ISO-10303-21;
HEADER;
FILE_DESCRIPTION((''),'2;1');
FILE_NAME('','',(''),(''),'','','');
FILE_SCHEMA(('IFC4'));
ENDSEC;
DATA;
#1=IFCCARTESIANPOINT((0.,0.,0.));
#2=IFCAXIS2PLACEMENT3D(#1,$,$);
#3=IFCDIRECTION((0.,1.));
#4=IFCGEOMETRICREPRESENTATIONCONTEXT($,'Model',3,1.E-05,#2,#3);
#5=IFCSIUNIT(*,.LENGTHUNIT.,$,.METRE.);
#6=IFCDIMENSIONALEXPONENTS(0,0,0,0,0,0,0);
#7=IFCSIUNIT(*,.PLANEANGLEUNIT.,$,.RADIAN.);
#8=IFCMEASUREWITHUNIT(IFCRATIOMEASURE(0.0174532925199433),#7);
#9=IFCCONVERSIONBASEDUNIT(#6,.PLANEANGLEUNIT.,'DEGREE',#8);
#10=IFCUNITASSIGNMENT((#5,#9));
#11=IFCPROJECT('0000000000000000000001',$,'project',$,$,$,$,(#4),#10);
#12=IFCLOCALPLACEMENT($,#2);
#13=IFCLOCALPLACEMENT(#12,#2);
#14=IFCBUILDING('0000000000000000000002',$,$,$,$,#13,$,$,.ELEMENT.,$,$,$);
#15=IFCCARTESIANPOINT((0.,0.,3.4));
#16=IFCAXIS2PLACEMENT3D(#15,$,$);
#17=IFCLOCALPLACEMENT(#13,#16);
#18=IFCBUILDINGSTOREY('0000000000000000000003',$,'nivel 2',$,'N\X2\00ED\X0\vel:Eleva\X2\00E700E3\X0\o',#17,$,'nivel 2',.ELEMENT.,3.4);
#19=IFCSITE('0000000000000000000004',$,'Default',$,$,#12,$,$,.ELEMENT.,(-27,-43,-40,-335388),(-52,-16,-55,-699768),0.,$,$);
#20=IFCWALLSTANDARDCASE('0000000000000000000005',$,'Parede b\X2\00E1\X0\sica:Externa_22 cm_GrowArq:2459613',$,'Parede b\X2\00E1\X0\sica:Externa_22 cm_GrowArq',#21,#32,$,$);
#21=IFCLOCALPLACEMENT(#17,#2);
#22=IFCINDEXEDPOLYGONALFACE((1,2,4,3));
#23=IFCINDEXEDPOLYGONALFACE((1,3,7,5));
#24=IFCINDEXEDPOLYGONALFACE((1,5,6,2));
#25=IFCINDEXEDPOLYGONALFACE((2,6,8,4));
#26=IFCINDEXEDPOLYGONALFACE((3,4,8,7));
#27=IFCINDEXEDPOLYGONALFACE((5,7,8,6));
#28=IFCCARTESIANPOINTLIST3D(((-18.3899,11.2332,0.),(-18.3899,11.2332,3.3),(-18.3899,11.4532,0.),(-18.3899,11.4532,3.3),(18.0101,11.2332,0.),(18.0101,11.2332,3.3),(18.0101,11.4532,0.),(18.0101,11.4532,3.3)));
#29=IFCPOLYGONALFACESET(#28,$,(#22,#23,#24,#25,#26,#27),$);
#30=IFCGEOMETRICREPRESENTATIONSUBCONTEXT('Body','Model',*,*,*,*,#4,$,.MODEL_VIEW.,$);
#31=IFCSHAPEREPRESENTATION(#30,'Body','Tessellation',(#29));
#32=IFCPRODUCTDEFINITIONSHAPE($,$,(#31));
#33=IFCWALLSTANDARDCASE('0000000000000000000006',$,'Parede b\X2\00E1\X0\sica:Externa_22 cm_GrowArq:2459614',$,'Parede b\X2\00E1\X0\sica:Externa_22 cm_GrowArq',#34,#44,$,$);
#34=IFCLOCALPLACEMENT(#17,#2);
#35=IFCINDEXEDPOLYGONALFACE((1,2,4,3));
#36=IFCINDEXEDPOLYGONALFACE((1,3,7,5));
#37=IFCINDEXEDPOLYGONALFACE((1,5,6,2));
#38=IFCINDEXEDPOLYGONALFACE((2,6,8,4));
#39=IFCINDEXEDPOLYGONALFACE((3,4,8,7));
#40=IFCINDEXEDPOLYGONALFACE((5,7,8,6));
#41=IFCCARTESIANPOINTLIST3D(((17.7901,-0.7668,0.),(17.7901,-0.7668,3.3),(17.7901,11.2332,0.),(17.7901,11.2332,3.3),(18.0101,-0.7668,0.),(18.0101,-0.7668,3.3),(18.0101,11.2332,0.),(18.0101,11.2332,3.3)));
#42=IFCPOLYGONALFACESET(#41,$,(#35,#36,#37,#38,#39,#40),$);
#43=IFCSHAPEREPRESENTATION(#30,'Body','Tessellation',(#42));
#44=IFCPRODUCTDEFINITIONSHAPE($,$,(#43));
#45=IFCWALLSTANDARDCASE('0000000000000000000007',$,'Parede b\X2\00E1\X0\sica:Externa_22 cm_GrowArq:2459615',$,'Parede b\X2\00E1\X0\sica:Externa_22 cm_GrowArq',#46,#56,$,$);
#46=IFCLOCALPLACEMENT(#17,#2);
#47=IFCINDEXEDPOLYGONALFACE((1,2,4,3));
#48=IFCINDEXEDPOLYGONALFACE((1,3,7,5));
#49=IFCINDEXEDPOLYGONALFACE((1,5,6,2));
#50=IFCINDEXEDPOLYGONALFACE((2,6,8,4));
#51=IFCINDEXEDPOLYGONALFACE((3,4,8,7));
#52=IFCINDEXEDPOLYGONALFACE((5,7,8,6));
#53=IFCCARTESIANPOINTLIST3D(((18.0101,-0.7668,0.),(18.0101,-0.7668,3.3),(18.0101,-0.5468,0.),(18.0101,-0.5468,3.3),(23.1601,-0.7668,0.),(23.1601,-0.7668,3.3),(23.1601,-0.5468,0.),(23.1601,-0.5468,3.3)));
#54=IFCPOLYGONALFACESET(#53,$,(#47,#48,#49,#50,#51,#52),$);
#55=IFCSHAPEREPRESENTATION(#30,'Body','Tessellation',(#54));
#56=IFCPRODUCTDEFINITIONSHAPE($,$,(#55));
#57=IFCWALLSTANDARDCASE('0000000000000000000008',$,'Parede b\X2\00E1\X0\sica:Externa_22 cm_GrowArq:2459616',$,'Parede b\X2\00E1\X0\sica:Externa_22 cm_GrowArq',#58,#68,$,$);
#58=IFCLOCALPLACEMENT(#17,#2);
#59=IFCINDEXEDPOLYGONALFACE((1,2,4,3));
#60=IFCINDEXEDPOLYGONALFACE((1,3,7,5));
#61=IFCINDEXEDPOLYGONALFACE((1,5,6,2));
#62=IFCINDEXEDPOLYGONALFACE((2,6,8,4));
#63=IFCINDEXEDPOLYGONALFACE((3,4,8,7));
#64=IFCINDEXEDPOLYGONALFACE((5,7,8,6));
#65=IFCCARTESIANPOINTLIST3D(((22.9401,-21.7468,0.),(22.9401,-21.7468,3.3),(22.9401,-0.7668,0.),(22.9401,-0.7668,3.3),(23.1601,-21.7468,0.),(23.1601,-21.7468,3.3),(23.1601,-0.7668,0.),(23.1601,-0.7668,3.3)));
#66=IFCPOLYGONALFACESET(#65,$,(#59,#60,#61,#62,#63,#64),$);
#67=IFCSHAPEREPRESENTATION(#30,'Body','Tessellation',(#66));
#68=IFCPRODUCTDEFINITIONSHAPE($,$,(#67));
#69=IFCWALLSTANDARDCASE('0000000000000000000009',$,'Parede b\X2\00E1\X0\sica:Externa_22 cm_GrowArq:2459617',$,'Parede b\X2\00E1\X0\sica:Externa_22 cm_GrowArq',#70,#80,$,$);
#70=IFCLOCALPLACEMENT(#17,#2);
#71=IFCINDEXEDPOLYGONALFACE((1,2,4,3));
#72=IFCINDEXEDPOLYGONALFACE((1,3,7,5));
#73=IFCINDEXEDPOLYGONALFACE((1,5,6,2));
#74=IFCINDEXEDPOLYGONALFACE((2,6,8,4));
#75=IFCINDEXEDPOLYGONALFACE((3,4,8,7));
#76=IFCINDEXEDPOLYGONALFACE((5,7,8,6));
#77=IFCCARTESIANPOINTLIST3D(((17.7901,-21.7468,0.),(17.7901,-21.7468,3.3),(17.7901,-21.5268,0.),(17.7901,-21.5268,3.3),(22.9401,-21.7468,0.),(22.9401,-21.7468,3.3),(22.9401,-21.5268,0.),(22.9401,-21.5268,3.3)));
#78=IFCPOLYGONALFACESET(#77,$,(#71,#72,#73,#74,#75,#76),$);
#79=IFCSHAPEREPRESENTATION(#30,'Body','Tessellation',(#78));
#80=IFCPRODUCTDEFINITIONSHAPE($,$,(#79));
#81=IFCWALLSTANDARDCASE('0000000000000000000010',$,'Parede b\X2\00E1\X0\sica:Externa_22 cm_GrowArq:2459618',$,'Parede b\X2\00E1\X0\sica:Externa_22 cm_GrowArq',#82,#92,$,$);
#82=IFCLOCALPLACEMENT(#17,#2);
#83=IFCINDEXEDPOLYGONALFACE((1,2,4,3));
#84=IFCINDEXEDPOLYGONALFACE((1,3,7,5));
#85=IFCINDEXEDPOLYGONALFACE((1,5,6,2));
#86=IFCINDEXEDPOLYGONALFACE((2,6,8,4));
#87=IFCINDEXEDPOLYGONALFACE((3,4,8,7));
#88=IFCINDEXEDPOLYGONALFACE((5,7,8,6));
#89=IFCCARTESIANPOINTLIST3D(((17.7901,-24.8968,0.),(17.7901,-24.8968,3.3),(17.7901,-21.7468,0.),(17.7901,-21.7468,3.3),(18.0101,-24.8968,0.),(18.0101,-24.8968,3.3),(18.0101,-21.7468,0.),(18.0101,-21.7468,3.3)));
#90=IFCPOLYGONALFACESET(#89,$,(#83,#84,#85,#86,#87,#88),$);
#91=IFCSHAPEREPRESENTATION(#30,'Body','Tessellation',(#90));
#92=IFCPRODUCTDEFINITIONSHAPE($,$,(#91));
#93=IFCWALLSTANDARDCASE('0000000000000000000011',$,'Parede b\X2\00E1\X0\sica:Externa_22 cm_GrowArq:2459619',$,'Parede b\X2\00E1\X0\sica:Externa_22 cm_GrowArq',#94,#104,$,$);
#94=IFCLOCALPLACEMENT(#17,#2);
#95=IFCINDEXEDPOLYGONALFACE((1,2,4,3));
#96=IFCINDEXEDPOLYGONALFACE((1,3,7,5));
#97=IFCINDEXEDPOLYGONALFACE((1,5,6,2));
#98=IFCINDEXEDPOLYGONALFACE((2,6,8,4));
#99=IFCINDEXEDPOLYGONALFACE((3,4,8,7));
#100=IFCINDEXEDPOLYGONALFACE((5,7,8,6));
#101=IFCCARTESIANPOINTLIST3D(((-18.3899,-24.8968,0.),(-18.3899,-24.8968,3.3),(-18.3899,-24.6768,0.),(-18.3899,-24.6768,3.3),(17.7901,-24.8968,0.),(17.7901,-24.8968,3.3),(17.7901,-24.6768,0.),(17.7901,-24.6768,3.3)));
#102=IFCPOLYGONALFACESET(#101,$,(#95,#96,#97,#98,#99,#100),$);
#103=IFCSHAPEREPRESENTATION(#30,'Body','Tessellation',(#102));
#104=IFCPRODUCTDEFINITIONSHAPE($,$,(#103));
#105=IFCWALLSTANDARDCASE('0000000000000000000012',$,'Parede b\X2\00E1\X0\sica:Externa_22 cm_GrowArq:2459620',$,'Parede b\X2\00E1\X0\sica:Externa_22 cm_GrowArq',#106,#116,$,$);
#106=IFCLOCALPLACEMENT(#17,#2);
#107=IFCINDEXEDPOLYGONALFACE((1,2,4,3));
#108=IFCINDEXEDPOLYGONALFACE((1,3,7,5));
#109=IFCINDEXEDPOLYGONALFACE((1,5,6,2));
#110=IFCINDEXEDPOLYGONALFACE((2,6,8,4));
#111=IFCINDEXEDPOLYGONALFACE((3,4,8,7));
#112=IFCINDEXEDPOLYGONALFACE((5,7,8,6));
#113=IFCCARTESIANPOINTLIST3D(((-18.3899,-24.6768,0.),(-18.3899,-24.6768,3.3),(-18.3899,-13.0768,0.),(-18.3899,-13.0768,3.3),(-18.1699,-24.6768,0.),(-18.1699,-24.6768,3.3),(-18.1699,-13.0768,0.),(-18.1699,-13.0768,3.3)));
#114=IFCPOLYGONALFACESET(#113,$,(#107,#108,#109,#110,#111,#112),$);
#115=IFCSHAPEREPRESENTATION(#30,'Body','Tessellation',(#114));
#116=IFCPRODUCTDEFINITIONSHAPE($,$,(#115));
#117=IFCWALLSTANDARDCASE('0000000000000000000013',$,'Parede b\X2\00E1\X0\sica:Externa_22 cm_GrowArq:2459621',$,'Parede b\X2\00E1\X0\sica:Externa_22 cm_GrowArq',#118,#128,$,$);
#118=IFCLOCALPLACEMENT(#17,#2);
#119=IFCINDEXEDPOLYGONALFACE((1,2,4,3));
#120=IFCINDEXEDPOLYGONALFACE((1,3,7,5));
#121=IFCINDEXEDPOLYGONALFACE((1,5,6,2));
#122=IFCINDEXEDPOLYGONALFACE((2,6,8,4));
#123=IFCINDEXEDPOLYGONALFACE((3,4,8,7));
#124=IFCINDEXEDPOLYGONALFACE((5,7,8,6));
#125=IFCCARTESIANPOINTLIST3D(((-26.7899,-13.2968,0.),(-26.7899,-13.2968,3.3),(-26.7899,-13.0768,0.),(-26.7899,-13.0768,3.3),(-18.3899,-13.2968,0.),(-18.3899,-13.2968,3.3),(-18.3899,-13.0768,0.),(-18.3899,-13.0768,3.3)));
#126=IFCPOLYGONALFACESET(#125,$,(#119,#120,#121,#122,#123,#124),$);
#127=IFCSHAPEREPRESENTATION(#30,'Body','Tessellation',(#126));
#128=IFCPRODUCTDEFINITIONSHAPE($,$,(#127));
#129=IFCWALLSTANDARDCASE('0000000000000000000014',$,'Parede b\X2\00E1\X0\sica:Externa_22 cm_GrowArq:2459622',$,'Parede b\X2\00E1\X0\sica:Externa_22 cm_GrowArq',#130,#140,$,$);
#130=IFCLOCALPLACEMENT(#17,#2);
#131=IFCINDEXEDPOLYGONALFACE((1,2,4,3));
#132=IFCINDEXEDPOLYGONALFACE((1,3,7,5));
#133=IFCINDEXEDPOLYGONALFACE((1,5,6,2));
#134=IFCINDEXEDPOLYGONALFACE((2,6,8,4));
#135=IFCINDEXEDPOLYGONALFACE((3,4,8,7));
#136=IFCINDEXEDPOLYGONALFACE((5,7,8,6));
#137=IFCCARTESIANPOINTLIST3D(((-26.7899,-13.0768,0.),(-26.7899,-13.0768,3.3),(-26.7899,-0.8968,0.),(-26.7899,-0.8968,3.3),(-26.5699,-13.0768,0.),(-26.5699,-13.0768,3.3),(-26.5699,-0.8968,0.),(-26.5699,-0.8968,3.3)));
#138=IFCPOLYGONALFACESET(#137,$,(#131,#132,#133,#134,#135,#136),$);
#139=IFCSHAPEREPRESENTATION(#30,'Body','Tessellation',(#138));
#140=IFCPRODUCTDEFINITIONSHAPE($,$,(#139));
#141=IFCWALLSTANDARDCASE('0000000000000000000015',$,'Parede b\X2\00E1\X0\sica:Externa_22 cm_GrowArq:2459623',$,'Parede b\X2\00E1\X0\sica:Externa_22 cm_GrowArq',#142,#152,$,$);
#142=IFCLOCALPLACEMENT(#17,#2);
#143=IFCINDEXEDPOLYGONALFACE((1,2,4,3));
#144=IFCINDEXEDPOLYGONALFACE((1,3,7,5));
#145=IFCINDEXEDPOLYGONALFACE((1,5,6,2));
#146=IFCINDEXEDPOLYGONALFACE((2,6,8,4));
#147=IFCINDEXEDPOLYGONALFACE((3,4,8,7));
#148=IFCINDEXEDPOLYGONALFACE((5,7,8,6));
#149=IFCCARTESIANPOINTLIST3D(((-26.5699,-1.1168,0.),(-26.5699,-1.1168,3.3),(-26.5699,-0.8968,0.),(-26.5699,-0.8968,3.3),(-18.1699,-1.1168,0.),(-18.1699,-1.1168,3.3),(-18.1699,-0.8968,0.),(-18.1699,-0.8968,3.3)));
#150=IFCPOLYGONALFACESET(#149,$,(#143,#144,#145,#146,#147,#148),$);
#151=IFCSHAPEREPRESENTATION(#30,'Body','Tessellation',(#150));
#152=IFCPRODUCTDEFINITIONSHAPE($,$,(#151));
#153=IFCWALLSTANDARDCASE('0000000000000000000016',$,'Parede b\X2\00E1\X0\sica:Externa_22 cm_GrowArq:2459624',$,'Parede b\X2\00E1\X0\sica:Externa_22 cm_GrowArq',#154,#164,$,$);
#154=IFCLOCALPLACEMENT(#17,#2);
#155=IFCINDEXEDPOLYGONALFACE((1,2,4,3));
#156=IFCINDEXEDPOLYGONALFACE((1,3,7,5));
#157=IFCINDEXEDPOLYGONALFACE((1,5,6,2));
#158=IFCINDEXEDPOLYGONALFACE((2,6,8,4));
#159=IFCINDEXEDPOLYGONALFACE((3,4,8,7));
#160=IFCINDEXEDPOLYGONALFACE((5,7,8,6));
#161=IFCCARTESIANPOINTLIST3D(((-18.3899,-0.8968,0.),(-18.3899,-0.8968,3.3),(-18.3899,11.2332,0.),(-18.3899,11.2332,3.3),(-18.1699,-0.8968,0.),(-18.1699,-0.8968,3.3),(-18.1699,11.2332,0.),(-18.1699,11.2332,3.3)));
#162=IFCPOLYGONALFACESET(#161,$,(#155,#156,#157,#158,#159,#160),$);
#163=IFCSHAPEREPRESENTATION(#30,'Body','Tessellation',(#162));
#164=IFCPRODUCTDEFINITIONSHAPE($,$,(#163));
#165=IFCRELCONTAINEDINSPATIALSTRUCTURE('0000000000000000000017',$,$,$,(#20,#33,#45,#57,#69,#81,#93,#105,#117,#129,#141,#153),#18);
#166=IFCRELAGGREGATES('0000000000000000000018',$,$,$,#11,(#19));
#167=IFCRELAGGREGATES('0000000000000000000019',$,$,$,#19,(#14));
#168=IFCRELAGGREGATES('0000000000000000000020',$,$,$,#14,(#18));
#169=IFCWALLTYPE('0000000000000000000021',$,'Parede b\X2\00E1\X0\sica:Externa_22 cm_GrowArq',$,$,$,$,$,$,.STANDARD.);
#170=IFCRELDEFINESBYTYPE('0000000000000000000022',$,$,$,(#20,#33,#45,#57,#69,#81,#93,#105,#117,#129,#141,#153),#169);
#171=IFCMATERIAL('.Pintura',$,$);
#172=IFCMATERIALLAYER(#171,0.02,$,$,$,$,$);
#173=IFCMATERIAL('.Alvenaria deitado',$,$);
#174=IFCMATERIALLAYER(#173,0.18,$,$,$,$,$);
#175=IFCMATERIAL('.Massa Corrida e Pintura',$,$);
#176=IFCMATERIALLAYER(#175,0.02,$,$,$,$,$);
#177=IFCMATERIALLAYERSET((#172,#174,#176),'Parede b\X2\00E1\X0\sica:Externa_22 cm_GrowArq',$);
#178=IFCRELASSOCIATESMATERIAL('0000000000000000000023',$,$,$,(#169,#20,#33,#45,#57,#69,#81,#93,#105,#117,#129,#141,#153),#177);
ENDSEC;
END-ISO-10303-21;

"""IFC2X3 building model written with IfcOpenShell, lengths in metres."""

from ifc_helpers import new_model, entity, si_unit, converted_unit, direction, frame, frame_2d, origin, place, context, subcontext, project, spatial, rectangle, extrude, material, layer, layer_set, layer_usage, type_object, element, save


model = new_model("IFC2X3")

# Units and contexts
model_context = context("Model", 3, precision=1e-05, world=origin(), true_north=direction((0.0, 1.0)))
body_context = subcontext(model_context, "Body", "Model", "MODEL_VIEW")
ifc_project = project(units=[si_unit("LENGTHUNIT", "METRE"), converted_unit("PLANEANGLEUNIT", "DEGREE", entity("IfcRatioMeasure", 0.0174532925199433), si_unit("PLANEANGLEUNIT", "RADIAN"), dimensions=[0, 0, 0, 0, 0, 0, 0])], contexts=[model_context])

# Site, building, storey
site_placement = place(None, origin())
site = spatial("IfcSite", under=ifc_project, at=site_placement, Name="Default", CompositionType="ELEMENT", RefLatitude=(-27, -43, -40, -335388), RefLongitude=(-52, -16, -55, -699768), RefElevation=0.0)
building_placement = place(site_placement, origin())
building = spatial("IfcBuilding", under=site, at=building_placement, CompositionType="ELEMENT")
storey_placement = place(building_placement, frame((0.0, 0.0, 3.4)))
storey = spatial("IfcBuildingStorey", under=building, at=storey_placement, Name="nivel 2", ObjectType="Nível:Elevação", LongName="nivel 2", CompositionType="ELEMENT", Elevation=3.4)

# Walls
ifc_material_1 = material(Name=".Pintura")
ifc_layer_1 = layer(ifc_material_1, 0.02)
ifc_material_2 = material(Name=".Alvenaria deitado")
ifc_layer_2 = layer(ifc_material_2, 0.18)
ifc_material_3 = material(Name=".Massa Corrida e Pintura")
ifc_layer_3 = layer(ifc_material_3, 0.02)
ifc_layer_set_1 = layer_set([ifc_layer_1, ifc_layer_2, ifc_layer_3], Name="Parede básica:Externa_22 cm_GrowArq")
ifc_layer_usage_1 = layer_usage(ifc_layer_set_1, "AXIS2", "NEGATIVE", 0.11)
wall_type = type_object("IfcWallType", Name="Parede básica:Externa_22 cm_GrowArq", PredefinedType="STANDARD", material=ifc_layer_set_1)
wall_1_placement = place(storey_placement, frame((-18.3899, 11.3432, 0.0)))
element("IfcWallStandardCase", 1, at=wall_1_placement, inside=storey, type_object=wall_type, material=ifc_layer_usage_1, Name="Parede básica:Externa_22 cm_GrowArq:2459613", ObjectType="Parede básica:Externa_22 cm_GrowArq", context=body_context, shape_type="SweptSolid", body=[
    extrude(rectangle(XDim=36.4, YDim=0.22, at=frame_2d((18.2, 0.0), x_axis=(-1.0, 0.0))), origin(), (0.0, 0.0, 1.0), 3.3),
])
ifc_layer_usage_2 = layer_usage(ifc_layer_set_1, "AXIS2", "NEGATIVE", 0.11)
wall_2_placement = place(storey_placement, frame((17.9001, 11.2332, 0.0), z_axis=(0.0, 0.0, 1.0), x_axis=(0.0, -1.0, 0.0)))
element("IfcWallStandardCase", 2, at=wall_2_placement, inside=storey, type_object=wall_type, material=ifc_layer_usage_2, Name="Parede básica:Externa_22 cm_GrowArq:2459614", ObjectType="Parede básica:Externa_22 cm_GrowArq", context=body_context, shape_type="SweptSolid", body=[
    extrude(rectangle(XDim=12.0, YDim=0.22, at=frame_2d((6.0, 0.0), x_axis=(-1.0, 0.0))), origin(), (0.0, 0.0, 1.0), 3.3),
])
ifc_layer_usage_3 = layer_usage(ifc_layer_set_1, "AXIS2", "NEGATIVE", 0.11)
wall_3_placement = place(storey_placement, frame((18.0101, -0.6568, 0.0)))
element("IfcWallStandardCase", 3, at=wall_3_placement, inside=storey, type_object=wall_type, material=ifc_layer_usage_3, Name="Parede básica:Externa_22 cm_GrowArq:2459615", ObjectType="Parede básica:Externa_22 cm_GrowArq", context=body_context, shape_type="SweptSolid", body=[
    extrude(rectangle(XDim=5.15, YDim=0.22, at=frame_2d((2.575, 0.0), x_axis=(-1.0, 0.0))), origin(), (0.0, 0.0, 1.0), 3.3),
])
ifc_layer_usage_4 = layer_usage(ifc_layer_set_1, "AXIS2", "NEGATIVE", 0.11)
wall_4_placement = place(storey_placement, frame((23.0501, -0.7668, 0.0), z_axis=(0.0, 0.0, 1.0), x_axis=(0.0, -1.0, 0.0)))
element("IfcWallStandardCase", 4, at=wall_4_placement, inside=storey, type_object=wall_type, material=ifc_layer_usage_4, Name="Parede básica:Externa_22 cm_GrowArq:2459616", ObjectType="Parede básica:Externa_22 cm_GrowArq", context=body_context, shape_type="SweptSolid", body=[
    extrude(rectangle(XDim=20.98, YDim=0.22, at=frame_2d((10.49, 0.0), x_axis=(-1.0, 0.0))), origin(), (0.0, 0.0, 1.0), 3.3),
])
ifc_layer_usage_5 = layer_usage(ifc_layer_set_1, "AXIS2", "NEGATIVE", 0.11)
wall_5_placement = place(storey_placement, frame((22.9401, -21.6368, 0.0), z_axis=(0.0, 0.0, 1.0), x_axis=(-1.0, 0.0, 0.0)))
element("IfcWallStandardCase", 5, at=wall_5_placement, inside=storey, type_object=wall_type, material=ifc_layer_usage_5, Name="Parede básica:Externa_22 cm_GrowArq:2459617", ObjectType="Parede básica:Externa_22 cm_GrowArq", context=body_context, shape_type="SweptSolid", body=[
    extrude(rectangle(XDim=5.15, YDim=0.22, at=frame_2d((2.575, 0.0), x_axis=(-1.0, 0.0))), origin(), (0.0, 0.0, 1.0), 3.3),
])
ifc_layer_usage_6 = layer_usage(ifc_layer_set_1, "AXIS2", "NEGATIVE", 0.11)
wall_6_placement = place(storey_placement, frame((17.9001, -21.7468, 0.0), z_axis=(0.0, 0.0, 1.0), x_axis=(0.0, -1.0, 0.0)))
element("IfcWallStandardCase", 6, at=wall_6_placement, inside=storey, type_object=wall_type, material=ifc_layer_usage_6, Name="Parede básica:Externa_22 cm_GrowArq:2459618", ObjectType="Parede básica:Externa_22 cm_GrowArq", context=body_context, shape_type="SweptSolid", body=[
    extrude(rectangle(XDim=3.15, YDim=0.22, at=frame_2d((1.575, 0.0), x_axis=(-1.0, 0.0))), origin(), (0.0, 0.0, 1.0), 3.3),
])
ifc_layer_usage_7 = layer_usage(ifc_layer_set_1, "AXIS2", "NEGATIVE", 0.11)
wall_7_placement = place(storey_placement, frame((17.7901, -24.7868, 0.0), z_axis=(0.0, 0.0, 1.0), x_axis=(-1.0, 0.0, 0.0)))
element("IfcWallStandardCase", 7, at=wall_7_placement, inside=storey, type_object=wall_type, material=ifc_layer_usage_7, Name="Parede básica:Externa_22 cm_GrowArq:2459619", ObjectType="Parede básica:Externa_22 cm_GrowArq", context=body_context, shape_type="SweptSolid", body=[
    extrude(rectangle(XDim=36.18, YDim=0.22, at=frame_2d((18.09, 0.0), x_axis=(-1.0, 0.0))), origin(), (0.0, 0.0, 1.0), 3.3),
])
ifc_layer_usage_8 = layer_usage(ifc_layer_set_1, "AXIS2", "NEGATIVE", 0.11)
wall_8_placement = place(storey_placement, frame((-18.2799, -24.6768, 0.0), z_axis=(0.0, 0.0, 1.0), x_axis=(0.0, 1.0, 0.0)))
element("IfcWallStandardCase", 8, at=wall_8_placement, inside=storey, type_object=wall_type, material=ifc_layer_usage_8, Name="Parede básica:Externa_22 cm_GrowArq:2459620", ObjectType="Parede básica:Externa_22 cm_GrowArq", context=body_context, shape_type="SweptSolid", body=[
    extrude(rectangle(XDim=11.6, YDim=0.22, at=frame_2d((5.8, 0.0), x_axis=(-1.0, 0.0))), origin(), (0.0, 0.0, 1.0), 3.3),
])
ifc_layer_usage_9 = layer_usage(ifc_layer_set_1, "AXIS2", "NEGATIVE", 0.11)
wall_9_placement = place(storey_placement, frame((-18.3899, -13.1868, 0.0), z_axis=(0.0, 0.0, 1.0), x_axis=(-1.0, 0.0, 0.0)))
element("IfcWallStandardCase", 9, at=wall_9_placement, inside=storey, type_object=wall_type, material=ifc_layer_usage_9, Name="Parede básica:Externa_22 cm_GrowArq:2459621", ObjectType="Parede básica:Externa_22 cm_GrowArq", context=body_context, shape_type="SweptSolid", body=[
    extrude(rectangle(XDim=8.4, YDim=0.22, at=frame_2d((4.2, 0.0), x_axis=(-1.0, 0.0))), origin(), (0.0, 0.0, 1.0), 3.3),
])
ifc_layer_usage_10 = layer_usage(ifc_layer_set_1, "AXIS2", "NEGATIVE", 0.11)
wall_10_placement = place(storey_placement, frame((-26.6799, -13.0768, 0.0), z_axis=(0.0, 0.0, 1.0), x_axis=(0.0, 1.0, 0.0)))
element("IfcWallStandardCase", 10, at=wall_10_placement, inside=storey, type_object=wall_type, material=ifc_layer_usage_10, Name="Parede básica:Externa_22 cm_GrowArq:2459622", ObjectType="Parede básica:Externa_22 cm_GrowArq", context=body_context, shape_type="SweptSolid", body=[
    extrude(rectangle(XDim=12.18, YDim=0.22, at=frame_2d((6.09, 0.0), x_axis=(-1.0, 0.0))), origin(), (0.0, 0.0, 1.0), 3.3),
])
ifc_layer_usage_11 = layer_usage(ifc_layer_set_1, "AXIS2", "NEGATIVE", 0.11)
wall_11_placement = place(storey_placement, frame((-26.5699, -1.0068, 0.0)))
element("IfcWallStandardCase", 11, at=wall_11_placement, inside=storey, type_object=wall_type, material=ifc_layer_usage_11, Name="Parede básica:Externa_22 cm_GrowArq:2459623", ObjectType="Parede básica:Externa_22 cm_GrowArq", context=body_context, shape_type="SweptSolid", body=[
    extrude(rectangle(XDim=8.4, YDim=0.22, at=frame_2d((4.2, 0.0), x_axis=(-1.0, 0.0))), origin(), (0.0, 0.0, 1.0), 3.3),
])
ifc_layer_usage_12 = layer_usage(ifc_layer_set_1, "AXIS2", "NEGATIVE", 0.11)
wall_12_placement = place(storey_placement, frame((-18.2799, -0.8968, 0.0), z_axis=(0.0, 0.0, 1.0), x_axis=(0.0, 1.0, 0.0)))
element("IfcWallStandardCase", 12, at=wall_12_placement, inside=storey, type_object=wall_type, material=ifc_layer_usage_12, Name="Parede básica:Externa_22 cm_GrowArq:2459624", ObjectType="Parede básica:Externa_22 cm_GrowArq", context=body_context, shape_type="SweptSolid", body=[
    extrude(rectangle(XDim=12.13, YDim=0.22, at=frame_2d((6.065, 0.0), x_axis=(-1.0, 0.0))), origin(), (0.0, 0.0, 1.0), 3.3),
])

save(model, "model.ifc")
